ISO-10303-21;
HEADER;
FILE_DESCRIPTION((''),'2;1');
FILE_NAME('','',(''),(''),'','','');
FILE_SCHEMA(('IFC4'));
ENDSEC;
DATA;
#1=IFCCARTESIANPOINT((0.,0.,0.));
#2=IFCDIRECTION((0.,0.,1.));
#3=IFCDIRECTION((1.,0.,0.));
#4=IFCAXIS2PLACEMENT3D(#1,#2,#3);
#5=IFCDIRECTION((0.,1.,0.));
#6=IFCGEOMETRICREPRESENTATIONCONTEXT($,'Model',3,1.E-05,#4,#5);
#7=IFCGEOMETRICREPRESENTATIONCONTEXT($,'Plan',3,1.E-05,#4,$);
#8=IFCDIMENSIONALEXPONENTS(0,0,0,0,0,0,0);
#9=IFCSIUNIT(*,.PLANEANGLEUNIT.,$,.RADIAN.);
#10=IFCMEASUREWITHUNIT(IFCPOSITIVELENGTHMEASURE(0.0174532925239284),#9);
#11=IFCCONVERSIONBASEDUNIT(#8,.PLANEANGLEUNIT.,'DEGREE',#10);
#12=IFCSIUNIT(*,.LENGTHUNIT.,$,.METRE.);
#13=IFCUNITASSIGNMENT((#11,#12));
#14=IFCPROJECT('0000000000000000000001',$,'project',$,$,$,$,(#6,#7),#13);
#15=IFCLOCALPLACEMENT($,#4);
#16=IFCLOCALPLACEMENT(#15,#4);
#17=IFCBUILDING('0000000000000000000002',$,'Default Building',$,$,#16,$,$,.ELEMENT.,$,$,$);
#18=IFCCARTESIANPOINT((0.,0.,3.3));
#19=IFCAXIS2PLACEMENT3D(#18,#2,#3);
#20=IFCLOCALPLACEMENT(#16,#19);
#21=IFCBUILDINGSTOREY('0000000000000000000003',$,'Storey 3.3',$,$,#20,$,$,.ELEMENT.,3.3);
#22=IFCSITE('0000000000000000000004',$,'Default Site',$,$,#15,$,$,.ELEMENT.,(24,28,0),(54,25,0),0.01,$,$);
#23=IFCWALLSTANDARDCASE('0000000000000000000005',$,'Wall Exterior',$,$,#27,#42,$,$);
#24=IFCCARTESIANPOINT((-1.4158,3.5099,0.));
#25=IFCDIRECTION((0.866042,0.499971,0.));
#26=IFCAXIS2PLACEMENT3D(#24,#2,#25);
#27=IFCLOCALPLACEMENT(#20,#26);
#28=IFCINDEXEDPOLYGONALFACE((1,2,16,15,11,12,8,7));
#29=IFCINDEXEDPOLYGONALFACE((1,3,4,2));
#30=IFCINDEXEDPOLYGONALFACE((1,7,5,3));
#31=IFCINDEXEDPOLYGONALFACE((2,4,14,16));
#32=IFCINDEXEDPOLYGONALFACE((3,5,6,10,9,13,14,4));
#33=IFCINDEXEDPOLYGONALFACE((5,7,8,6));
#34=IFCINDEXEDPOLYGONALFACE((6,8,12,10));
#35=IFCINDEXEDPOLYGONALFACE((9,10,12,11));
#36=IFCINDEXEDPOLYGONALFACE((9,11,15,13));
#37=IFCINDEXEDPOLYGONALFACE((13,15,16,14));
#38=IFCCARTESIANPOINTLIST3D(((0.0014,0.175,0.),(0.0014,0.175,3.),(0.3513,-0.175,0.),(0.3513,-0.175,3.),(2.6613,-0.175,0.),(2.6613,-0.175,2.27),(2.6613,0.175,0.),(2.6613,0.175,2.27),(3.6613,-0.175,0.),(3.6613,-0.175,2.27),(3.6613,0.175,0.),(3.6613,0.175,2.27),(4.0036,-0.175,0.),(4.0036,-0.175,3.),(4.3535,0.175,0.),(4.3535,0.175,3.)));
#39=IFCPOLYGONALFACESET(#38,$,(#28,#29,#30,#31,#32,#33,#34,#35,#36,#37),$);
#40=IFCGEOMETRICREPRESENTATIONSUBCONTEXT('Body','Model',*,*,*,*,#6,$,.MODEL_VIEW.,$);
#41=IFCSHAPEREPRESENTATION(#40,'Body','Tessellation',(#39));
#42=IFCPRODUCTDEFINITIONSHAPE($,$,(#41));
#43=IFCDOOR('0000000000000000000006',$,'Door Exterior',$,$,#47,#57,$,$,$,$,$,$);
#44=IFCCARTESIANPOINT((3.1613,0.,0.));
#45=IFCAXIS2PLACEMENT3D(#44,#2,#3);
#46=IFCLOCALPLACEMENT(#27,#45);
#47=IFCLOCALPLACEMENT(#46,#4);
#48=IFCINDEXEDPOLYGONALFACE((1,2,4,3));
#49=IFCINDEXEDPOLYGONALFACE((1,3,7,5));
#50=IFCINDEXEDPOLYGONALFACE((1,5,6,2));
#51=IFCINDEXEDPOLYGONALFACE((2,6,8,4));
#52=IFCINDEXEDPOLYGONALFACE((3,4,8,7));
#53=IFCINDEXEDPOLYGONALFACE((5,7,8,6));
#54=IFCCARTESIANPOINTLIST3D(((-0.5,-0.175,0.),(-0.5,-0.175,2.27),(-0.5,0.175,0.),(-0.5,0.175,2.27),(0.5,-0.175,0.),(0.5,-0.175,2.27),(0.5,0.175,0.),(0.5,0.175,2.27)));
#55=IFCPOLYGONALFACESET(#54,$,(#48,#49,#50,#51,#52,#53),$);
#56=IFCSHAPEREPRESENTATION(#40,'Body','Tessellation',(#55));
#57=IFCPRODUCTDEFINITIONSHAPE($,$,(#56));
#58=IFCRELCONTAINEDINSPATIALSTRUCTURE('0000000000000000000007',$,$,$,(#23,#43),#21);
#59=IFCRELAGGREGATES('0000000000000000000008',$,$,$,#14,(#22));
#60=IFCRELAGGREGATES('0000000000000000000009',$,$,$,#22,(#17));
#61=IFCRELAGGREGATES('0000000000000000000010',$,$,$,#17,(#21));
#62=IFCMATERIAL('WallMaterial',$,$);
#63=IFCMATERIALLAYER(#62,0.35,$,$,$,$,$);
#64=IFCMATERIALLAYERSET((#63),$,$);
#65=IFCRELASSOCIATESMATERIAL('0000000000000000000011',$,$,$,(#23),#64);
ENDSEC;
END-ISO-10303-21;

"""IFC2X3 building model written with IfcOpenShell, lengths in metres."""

from ifc_helpers import new_model, entity, si_unit, converted_unit, direction, frame, origin_with_axes, place, context, subcontext, project, spatial, polyline, outline, extrude, material, layer, layer_set, layer_usage, element, fill, save


model = new_model("IFC2X3")

# Units and contexts
model_context = context("Model", 3, precision=1e-05, world=origin_with_axes(), true_north=direction((0.0, 1.0, 0.0)))
plan_context = context("Plan", 3, precision=1e-05, world=origin_with_axes())
body_context = subcontext(model_context, "Body", "Model", "MODEL_VIEW")
ifc_project = project(units=[converted_unit("PLANEANGLEUNIT", "DEGREE", entity("IfcPositiveLengthMeasure", 0.0174532925239284), si_unit("PLANEANGLEUNIT", "RADIAN"), dimensions=[0, 0, 0, 0, 0, 0, 0]), si_unit("LENGTHUNIT", "METRE")], contexts=[model_context, plan_context])

# Site, building, storey
site_placement = place(None, origin_with_axes())
site = spatial("IfcSite", under=ifc_project, at=site_placement, Name="Default Site", CompositionType="ELEMENT", RefLatitude=(24, 28, 0), RefLongitude=(54, 25, 0), RefElevation=0.01)
building_placement = place(site_placement, origin_with_axes())
building = spatial("IfcBuilding", under=site, at=building_placement, Name="Default Building", CompositionType="ELEMENT")
storey_placement = place(building_placement, frame((0.0, 0.0, 3.3), z_axis=(0.0, 0.0, 1.0), x_axis=(1.0, 0.0, 0.0)))
storey = spatial("IfcBuildingStorey", under=building, at=storey_placement, Name="Storey 3.3", CompositionType="ELEMENT", Elevation=3.3)

# Wall, opening, door
ifc_material_1 = material(Name="WallMaterial")
ifc_layer_1 = layer(ifc_material_1, 0.35)
ifc_layer_set_1 = layer_set([ifc_layer_1])
ifc_layer_usage_1 = layer_usage(ifc_layer_set_1, "AXIS2", "POSITIVE", -0.175)
wall_1_placement = place(storey_placement, frame((-1.4158, 3.5099, 0.0), z_axis=(0.0, 0.0, 1.0), x_axis=(0.866042, 0.499971, 0.0)))
wall_1 = element("IfcWallStandardCase", 1, at=wall_1_placement, inside=storey, material=ifc_layer_usage_1, Name="Wall Exterior", context=body_context, shape_type="SweptSolid", body=[
    extrude(outline(polyline([(4.0036, -0.175), (4.3535, 0.175), (0.0014, 0.175), (0.3513, -0.175), (4.0036, -0.175)])), origin_with_axes(), (0.0, 0.0, 1.0), 3.0),
])
opening_1_placement = place(wall_1_placement, frame((3.1613, 0.0, 0.0), z_axis=(0.0, 0.0, 1.0), x_axis=(1.0, 0.0, 0.0)))
opening_1 = element("IfcOpeningElement", 2, at=opening_1_placement, cuts=wall_1, context=body_context, shape_type="SweptSolid", body=[
    extrude(outline(polyline([(-0.5, 0.372), (0.5, 0.372), (0.5, -0.372), (-0.5, -0.372), (-0.5, 0.372)])), origin_with_axes(), (0.0, 0.0, 1.0), 2.27),
])
door_1_placement = place(opening_1_placement, origin_with_axes())
door_1 = element("IfcDoor", 3, at=door_1_placement, inside=storey, Name="Door Exterior", context=body_context, shape_type="SweptSolid", body=[
    extrude(outline(polyline([(-0.5, 0.175), (0.5, 0.175), (0.5, -0.175), (-0.5, -0.175), (-0.5, 0.175)])), origin_with_axes(), (0.0, 0.0, 1.0), 2.27),
])
fill(opening_1, door_1)

save(model, "model.ifc")
